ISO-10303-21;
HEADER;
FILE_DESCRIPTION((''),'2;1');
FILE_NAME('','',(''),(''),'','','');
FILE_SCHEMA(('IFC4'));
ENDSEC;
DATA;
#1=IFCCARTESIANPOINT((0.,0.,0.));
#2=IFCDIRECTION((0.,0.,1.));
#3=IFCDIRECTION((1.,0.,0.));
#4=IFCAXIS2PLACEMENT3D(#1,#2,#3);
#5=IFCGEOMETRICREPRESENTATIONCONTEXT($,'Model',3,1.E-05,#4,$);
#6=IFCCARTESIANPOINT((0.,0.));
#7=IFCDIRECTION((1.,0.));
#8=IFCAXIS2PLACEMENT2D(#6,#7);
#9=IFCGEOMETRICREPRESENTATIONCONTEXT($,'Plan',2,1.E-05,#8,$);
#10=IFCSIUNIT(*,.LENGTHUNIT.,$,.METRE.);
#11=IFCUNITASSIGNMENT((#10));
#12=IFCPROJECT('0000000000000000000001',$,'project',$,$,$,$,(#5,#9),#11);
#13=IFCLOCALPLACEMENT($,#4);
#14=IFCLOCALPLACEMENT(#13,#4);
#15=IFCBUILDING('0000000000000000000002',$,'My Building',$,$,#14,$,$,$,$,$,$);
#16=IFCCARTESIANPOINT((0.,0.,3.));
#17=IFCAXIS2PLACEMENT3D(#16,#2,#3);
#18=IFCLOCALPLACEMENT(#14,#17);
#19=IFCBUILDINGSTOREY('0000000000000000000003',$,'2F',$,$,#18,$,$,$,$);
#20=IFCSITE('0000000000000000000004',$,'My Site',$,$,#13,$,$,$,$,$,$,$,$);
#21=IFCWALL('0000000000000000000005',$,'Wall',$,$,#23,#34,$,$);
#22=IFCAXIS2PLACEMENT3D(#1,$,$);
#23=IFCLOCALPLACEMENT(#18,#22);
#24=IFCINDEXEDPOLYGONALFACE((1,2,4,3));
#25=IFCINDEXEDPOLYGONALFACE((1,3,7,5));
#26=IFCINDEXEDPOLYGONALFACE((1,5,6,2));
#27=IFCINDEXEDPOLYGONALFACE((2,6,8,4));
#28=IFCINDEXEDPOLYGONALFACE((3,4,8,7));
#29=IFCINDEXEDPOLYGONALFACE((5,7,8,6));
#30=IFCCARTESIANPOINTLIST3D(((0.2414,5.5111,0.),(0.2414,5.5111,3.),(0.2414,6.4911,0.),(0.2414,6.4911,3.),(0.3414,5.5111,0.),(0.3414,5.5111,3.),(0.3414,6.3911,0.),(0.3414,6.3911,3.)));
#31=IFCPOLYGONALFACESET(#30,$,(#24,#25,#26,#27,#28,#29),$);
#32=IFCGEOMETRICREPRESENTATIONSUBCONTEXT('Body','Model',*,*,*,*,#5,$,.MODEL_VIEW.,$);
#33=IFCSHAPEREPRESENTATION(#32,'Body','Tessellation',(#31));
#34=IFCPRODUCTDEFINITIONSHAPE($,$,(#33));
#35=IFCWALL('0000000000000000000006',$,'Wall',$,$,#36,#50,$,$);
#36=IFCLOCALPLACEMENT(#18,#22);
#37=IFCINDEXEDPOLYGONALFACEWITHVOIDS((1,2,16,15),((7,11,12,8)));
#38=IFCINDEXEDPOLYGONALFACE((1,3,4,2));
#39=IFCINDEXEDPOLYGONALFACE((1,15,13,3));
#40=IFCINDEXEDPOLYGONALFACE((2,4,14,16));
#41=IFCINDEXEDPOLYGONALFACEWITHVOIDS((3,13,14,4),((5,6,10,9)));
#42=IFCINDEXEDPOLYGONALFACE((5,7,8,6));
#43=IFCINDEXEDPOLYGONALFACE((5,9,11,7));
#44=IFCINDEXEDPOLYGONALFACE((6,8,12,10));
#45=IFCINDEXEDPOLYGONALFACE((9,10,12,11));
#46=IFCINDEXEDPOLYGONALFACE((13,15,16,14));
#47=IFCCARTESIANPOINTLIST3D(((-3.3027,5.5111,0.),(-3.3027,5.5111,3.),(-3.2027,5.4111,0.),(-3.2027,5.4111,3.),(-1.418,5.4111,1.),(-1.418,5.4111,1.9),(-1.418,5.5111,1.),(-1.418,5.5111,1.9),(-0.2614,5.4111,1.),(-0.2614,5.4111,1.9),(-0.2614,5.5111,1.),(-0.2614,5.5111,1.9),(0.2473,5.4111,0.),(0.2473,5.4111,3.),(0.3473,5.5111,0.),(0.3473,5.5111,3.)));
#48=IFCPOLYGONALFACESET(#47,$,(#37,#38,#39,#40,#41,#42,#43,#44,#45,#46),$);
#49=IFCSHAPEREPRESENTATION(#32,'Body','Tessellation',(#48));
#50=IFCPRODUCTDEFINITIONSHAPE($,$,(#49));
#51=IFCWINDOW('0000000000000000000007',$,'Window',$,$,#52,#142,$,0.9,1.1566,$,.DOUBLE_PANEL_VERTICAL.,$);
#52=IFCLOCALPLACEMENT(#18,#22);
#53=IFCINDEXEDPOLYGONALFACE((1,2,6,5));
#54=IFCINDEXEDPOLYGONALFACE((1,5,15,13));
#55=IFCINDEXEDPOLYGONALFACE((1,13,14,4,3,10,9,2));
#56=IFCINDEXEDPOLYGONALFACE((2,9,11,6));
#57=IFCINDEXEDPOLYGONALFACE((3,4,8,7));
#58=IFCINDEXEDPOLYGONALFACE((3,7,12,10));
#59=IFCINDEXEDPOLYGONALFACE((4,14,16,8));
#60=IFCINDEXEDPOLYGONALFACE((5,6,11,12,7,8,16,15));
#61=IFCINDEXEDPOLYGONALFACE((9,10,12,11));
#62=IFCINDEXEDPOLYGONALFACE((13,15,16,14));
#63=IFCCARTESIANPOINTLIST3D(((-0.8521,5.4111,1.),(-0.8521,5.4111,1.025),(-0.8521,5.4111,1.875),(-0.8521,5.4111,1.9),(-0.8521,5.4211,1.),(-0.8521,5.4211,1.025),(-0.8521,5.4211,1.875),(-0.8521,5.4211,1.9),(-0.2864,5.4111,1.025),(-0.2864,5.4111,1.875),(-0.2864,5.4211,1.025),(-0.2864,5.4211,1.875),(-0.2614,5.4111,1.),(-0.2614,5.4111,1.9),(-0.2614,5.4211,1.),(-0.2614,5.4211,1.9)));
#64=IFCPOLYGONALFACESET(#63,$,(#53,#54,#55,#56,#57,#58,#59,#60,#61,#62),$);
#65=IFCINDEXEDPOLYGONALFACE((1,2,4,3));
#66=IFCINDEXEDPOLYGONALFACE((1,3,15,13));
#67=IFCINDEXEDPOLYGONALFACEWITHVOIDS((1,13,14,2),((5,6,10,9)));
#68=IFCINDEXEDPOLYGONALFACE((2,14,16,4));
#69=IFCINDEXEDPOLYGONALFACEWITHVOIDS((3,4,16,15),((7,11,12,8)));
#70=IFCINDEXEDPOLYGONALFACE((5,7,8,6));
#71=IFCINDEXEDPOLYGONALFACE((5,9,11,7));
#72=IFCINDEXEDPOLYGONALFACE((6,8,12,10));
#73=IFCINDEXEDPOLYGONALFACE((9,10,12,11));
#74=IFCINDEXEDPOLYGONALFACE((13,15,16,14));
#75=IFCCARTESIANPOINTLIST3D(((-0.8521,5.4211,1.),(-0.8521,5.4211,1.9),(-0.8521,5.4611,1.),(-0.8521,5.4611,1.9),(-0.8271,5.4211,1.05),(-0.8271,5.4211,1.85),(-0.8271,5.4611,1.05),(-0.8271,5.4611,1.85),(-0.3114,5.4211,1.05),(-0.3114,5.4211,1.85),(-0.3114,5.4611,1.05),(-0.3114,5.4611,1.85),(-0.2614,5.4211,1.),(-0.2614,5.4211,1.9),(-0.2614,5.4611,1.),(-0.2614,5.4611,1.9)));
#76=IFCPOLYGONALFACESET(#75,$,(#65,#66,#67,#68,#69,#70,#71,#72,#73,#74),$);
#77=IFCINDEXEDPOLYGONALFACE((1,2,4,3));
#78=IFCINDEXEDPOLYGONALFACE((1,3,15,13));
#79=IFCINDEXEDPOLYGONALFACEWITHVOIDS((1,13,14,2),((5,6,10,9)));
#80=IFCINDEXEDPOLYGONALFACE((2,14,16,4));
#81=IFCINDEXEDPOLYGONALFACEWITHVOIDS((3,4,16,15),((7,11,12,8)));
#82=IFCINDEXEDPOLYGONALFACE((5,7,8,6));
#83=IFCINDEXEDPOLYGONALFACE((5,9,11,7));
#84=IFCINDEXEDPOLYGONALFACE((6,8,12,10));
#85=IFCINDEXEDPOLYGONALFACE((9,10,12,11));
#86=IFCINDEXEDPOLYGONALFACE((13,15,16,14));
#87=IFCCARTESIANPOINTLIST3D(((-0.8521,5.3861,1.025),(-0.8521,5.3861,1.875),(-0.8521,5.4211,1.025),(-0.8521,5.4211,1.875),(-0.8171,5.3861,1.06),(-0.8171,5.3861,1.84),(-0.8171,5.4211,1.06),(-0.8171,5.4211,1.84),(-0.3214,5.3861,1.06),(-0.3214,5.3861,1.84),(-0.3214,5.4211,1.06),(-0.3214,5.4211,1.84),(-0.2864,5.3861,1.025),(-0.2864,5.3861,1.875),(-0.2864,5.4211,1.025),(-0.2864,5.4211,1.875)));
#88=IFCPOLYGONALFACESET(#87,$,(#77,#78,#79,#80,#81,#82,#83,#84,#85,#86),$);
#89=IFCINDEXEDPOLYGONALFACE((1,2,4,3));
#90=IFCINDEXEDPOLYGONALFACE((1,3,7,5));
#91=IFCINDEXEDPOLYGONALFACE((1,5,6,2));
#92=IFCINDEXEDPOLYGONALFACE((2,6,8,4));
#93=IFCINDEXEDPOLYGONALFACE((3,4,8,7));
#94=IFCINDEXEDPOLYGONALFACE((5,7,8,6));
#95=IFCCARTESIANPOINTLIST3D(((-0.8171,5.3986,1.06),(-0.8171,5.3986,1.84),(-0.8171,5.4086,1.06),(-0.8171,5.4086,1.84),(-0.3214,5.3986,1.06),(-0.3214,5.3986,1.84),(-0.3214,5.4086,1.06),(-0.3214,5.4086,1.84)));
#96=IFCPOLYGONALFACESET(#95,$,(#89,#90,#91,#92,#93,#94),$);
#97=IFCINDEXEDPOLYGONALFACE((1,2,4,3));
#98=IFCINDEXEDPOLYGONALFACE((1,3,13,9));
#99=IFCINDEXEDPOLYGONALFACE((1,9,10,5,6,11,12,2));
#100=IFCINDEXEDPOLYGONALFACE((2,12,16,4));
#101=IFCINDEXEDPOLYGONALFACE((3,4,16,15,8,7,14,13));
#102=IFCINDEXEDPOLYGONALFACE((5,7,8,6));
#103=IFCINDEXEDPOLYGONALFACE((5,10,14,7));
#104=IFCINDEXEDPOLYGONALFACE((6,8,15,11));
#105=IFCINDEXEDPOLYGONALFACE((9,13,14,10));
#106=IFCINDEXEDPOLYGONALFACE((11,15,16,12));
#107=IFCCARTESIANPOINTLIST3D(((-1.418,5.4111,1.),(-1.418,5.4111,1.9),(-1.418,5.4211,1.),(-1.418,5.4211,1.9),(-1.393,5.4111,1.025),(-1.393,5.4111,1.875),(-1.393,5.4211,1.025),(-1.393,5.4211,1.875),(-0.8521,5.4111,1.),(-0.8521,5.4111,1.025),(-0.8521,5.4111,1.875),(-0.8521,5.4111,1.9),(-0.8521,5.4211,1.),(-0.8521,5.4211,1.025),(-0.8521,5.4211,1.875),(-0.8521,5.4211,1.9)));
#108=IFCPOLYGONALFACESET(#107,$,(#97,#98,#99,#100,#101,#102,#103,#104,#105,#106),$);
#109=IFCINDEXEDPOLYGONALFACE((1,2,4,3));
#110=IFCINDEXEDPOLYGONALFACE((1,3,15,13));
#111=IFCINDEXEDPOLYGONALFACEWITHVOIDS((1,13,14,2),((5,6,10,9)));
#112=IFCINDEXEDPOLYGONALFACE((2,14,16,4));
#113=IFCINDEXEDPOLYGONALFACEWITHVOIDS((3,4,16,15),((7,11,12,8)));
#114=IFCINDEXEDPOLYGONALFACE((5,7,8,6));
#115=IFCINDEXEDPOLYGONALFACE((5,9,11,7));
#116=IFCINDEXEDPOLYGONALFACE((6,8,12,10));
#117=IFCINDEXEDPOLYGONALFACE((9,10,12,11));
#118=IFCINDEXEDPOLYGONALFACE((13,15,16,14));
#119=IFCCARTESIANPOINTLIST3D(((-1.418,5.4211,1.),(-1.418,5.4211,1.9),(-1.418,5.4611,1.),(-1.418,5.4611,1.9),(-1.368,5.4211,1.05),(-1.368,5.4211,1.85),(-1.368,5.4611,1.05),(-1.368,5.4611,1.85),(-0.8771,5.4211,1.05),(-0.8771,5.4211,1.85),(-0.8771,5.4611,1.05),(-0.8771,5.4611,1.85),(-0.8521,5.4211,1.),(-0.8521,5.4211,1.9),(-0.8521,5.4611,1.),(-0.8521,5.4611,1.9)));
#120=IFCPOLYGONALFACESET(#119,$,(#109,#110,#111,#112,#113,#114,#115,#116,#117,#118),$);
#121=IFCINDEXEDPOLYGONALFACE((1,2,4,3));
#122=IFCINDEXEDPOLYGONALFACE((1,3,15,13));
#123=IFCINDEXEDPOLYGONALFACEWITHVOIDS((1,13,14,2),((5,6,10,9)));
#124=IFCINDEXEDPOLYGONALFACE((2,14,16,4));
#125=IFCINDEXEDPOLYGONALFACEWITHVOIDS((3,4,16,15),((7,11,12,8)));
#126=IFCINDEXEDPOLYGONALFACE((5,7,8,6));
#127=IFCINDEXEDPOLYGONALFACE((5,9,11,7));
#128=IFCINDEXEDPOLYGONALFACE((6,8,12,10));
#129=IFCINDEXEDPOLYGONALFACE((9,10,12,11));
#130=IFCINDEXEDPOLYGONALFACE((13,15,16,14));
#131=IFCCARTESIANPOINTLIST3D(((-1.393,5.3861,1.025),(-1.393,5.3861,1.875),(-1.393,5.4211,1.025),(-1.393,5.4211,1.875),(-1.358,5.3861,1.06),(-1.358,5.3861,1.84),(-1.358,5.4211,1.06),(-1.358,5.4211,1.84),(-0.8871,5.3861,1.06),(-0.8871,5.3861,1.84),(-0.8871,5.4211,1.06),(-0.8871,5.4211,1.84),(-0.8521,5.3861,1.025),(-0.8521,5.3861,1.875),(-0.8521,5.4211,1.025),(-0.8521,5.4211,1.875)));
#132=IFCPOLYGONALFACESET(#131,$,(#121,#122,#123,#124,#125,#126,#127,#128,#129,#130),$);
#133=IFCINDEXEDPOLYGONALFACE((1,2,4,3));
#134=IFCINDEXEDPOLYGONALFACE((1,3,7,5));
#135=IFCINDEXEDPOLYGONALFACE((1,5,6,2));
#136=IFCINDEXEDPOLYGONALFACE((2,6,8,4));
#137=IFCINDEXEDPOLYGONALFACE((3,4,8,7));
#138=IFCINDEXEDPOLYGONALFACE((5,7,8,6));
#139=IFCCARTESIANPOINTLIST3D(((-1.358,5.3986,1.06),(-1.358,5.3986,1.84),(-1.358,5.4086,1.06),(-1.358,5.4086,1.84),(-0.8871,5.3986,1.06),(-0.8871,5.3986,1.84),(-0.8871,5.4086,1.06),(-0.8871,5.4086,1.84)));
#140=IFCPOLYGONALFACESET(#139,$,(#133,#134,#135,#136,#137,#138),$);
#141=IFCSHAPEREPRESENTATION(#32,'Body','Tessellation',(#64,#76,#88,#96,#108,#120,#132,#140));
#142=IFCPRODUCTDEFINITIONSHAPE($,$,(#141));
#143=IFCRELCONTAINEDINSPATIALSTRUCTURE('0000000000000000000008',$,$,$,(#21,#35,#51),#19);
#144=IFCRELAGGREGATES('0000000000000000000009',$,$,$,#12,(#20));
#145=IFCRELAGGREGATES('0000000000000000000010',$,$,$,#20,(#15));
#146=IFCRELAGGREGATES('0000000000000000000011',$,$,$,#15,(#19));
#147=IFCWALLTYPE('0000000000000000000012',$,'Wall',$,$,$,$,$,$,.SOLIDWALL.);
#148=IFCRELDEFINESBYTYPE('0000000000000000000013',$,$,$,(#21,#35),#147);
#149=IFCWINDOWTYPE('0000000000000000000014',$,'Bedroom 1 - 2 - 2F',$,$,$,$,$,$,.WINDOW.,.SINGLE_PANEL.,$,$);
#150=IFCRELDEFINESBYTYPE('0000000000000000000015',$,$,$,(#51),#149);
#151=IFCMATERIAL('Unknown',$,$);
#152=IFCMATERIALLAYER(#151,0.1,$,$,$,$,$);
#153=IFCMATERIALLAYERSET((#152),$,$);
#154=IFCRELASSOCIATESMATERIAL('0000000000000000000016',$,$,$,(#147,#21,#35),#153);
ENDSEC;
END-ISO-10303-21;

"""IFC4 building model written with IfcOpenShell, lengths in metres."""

from ifc_helpers import new_model, entity, si_unit, frame, origin_with_axes, origin_2d_with_axis, place, context, subcontext, project, spatial, line, indexed_curve, outline, extrude, shape, source, transform, mapped, material, layer, layer_set, layer_usage, type_object, type_shapes, element, fill, save


model = new_model("IFC4")

# Units and contexts
model_context = context("Model", 3, precision=1e-05, world=origin_with_axes())
plan_context = context("Plan", 2, precision=1e-05, world=origin_2d_with_axis())
body_context_1 = subcontext(model_context, "Body", "Model", "MODEL_VIEW")
body_context_2 = subcontext(plan_context, "Body", "Plan", "PLAN_VIEW")
ifc_project = project(units=[si_unit("LENGTHUNIT", "METRE")], contexts=[model_context, plan_context])

# Site, building, storey
site_placement = place(None, origin_with_axes())
site = spatial("IfcSite", under=ifc_project, at=site_placement, Name="My Site")
building_placement = place(site_placement, origin_with_axes())
building = spatial("IfcBuilding", under=site, at=building_placement, Name="My Building")
storey_placement = place(building_placement, frame((0.0, 0.0, 3.0), z_axis=(0.0, 0.0, 1.0), x_axis=(1.0, 0.0, 0.0)))
storey = spatial("IfcBuildingStorey", under=building, at=storey_placement, Name="2F")

# Shared definitions
ifc_material = material(Name="Unknown")

# Wall
ifc_layer = layer(ifc_material, 0.1)
ifc_layer_set = layer_set([ifc_layer])
wall_type = type_object("IfcWallType", Name="Wall", PredefinedType="SOLIDWALL", material=ifc_layer_set)
ifc_layer_usage_1 = layer_usage(ifc_layer_set, "AXIS2", "POSITIVE", 0.0)
wall_1_placement = place(storey_placement, frame((0.2414, 6.4911, 0.0), z_axis=(0.0, 0.0, 1.0), x_axis=(0.0, -1.0, 0.0)))
element("IfcWall", 1, at=wall_1_placement, inside=storey, type_object=wall_type, material=ifc_layer_usage_1, Name="Wall", context=body_context_1, shape_type="SweptSolid", body=[
    extrude(outline(indexed_curve([(0.0, 0.0), (0.1, 0.1), (0.98, 0.1), (0.98, 0.0)], segments=[line(1, 2, 3, 4, 1)])), origin_with_axes(), (0.0, 0.0, 1.0), 3.0),
])

# Wall, opening, window
ifc_layer_usage_2 = layer_usage(ifc_layer_set, "AXIS2", "POSITIVE", 0.0)
wall_2_placement = place(storey_placement, frame((0.3473, 5.5111, 0.0), z_axis=(0.0, 0.0, 1.0), x_axis=(-1.0, 0.0, 0.0)))
wall_2 = element("IfcWall", 2, at=wall_2_placement, inside=storey, type_object=wall_type, material=ifc_layer_usage_2, Name="Wall", context=body_context_1, shape_type="SweptSolid", body=[
    extrude(outline(indexed_curve([(0.0, 0.0), (0.1, 0.1), (3.55, 0.1), (3.65, 0.0)], segments=[line(1, 2, 3, 4, 1)])), origin_with_axes(), (0.0, 0.0, 1.0), 3.0),
])
shared_shape_1 = source(origin_with_axes(), body_context_1, "Body", "SweptSolid", [
    extrude(outline(indexed_curve([(0.0, 0.0), (1.1566, 0.0), (1.1566, 0.9), (0.0, 0.9)], segments=[line(1, 2, 3, 4, 1)])), frame((0.0, -0.6, 0.0), z_axis=(0.0, -1.0, 0.0), x_axis=(1.0, 0.0, 0.0)), (0.0, 0.0, -1.0), 1.2),
])
opening_1_placement = place(wall_2_placement, frame((0.6086, 0.0, 1.0), z_axis=(0.0, 0.0, 1.0), x_axis=(1.0, 0.0, 0.0)))
opening_1 = element("IfcOpeningElement", 3, at=opening_1_placement, cuts=wall_2, PredefinedType="OPENING", context=body_context_1, shape_type="MappedRepresentation", body=[
    mapped(shared_shape_1, transform((0.0, 0.0, 0.0), x_axis=(1.0, 0.0, 0.0), y_axis=(0.0, 1.0, 0.0), z_axis=(0.0, 0.0, 1.0), scale=1.0)),
])
window_type_1 = type_object("IfcWindowType", Name="Bedroom 1 - 2 - 2F", PartitioningType="SINGLE_PANEL", PredefinedType="WINDOW")
shared_shape_2 = source(origin_with_axes(), body_context_1, "Body", "SweptSolid", [
    extrude(outline(indexed_curve([(0.5908, 0.0), (0.0, 0.0), (0.0, 0.9), (0.5908, 0.9), (0.5908, 0.875), (0.025, 0.875), (0.025, 0.025), (0.5908, 0.025)], segments=[line(1, 2, 3, 4, 5, 6, 7, 8, 1)])), frame((0.0, 0.09, 0.0), z_axis=(0.0, -1.0, 0.0), x_axis=(1.0, 0.0, 0.0)), (0.0, 0.0, -1.0), 0.01),
    extrude(outline(indexed_curve([(0.0, 0.0), (0.5908, 0.0), (0.5908, 0.9), (0.0, 0.9)], segments=[line(1, 2, 3, 4, 1)]), holes=[indexed_curve([(0.05, 0.05), (0.5658, 0.05), (0.5658, 0.85), (0.05, 0.85)], segments=[line(1, 2, 3, 4, 1)])]), frame((0.0, 0.05, 0.0), z_axis=(0.0, -1.0, 0.0), x_axis=(1.0, 0.0, 0.0)), (0.0, 0.0, -1.0), 0.04),
    extrude(outline(indexed_curve([(0.0, 0.0), (0.5658, 0.0), (0.5658, 0.85), (0.0, 0.85)], segments=[line(1, 2, 3, 4, 1)]), holes=[indexed_curve([(0.035, 0.035), (0.5308, 0.035), (0.5308, 0.815), (0.035, 0.815)], segments=[line(1, 2, 3, 4, 1)])]), frame((0.025, 0.09, 0.025), z_axis=(0.0, -1.0, 0.0), x_axis=(1.0, 0.0, 0.0)), (0.0, 0.0, -1.0), 0.035),
    extrude(outline(indexed_curve([(0.035, 0.035), (0.5308, 0.035), (0.5308, 0.815), (0.035, 0.815)], segments=[line(1, 2, 3, 4, 1)])), frame((0.025, 0.1025, 0.025), z_axis=(0.0, -1.0, 0.0), x_axis=(1.0, 0.0, 0.0)), (0.0, 0.0, -1.0), 0.01),
    extrude(outline(indexed_curve([(0.0, 0.9), (0.5659, 0.9), (0.5659, 0.0), (0.0, 0.0), (0.0, 0.025), (0.5409, 0.025), (0.5409, 0.875), (0.0, 0.875)], segments=[line(1, 2, 3, 4, 5, 6, 7, 8, 1)])), frame((0.5908, 0.09, 0.0), z_axis=(0.0, -1.0, 0.0), x_axis=(1.0, 0.0, 0.0)), (0.0, 0.0, -1.0), 0.01),
    extrude(outline(indexed_curve([(0.0, 0.0), (0.5659, 0.0), (0.5659, 0.9), (0.0, 0.9)], segments=[line(1, 2, 3, 4, 1)]), holes=[indexed_curve([(0.025, 0.05), (0.5159, 0.05), (0.5159, 0.85), (0.025, 0.85)], segments=[line(1, 2, 3, 4, 1)])]), frame((0.5908, 0.05, 0.0), z_axis=(0.0, -1.0, 0.0), x_axis=(1.0, 0.0, 0.0)), (0.0, 0.0, -1.0), 0.04),
    extrude(outline(indexed_curve([(0.0, 0.0), (0.5409, 0.0), (0.5409, 0.85), (0.0, 0.85)], segments=[line(1, 2, 3, 4, 1)]), holes=[indexed_curve([(0.035, 0.035), (0.5059, 0.035), (0.5059, 0.815), (0.035, 0.815)], segments=[line(1, 2, 3, 4, 1)])]), frame((0.5908, 0.09, 0.025), z_axis=(0.0, -1.0, 0.0), x_axis=(1.0, 0.0, 0.0)), (0.0, 0.0, -1.0), 0.035),
    extrude(outline(indexed_curve([(0.035, 0.035), (0.5059, 0.035), (0.5059, 0.815), (0.035, 0.815)], segments=[line(1, 2, 3, 4, 1)])), frame((0.5908, 0.1025, 0.025), z_axis=(0.0, -1.0, 0.0), x_axis=(1.0, 0.0, 0.0)), (0.0, 0.0, -1.0), 0.01),
])
shared_shape_3 = source(origin_with_axes(), body_context_2, "Body", "Curve2D", [
    entity("IfcIndexedPolyCurve", entity("IfcCartesianPointList2D", [[0.05, 0.05], [0.5658, 0.05]])),
    entity("IfcIndexedPolyCurve", entity("IfcCartesianPointList2D", [[0.0, 0.1], [0.025, 0.1], [0.025, 0.09], [0.05, 0.09], [0.05, 0.05], [0.0, 0.05]]), [entity("IfcLineIndex", [1, 2, 3, 4, 5, 6, 1])]),
    entity("IfcIndexedPolyCurve", entity("IfcCartesianPointList2D", [[0.5908, 0.1], [0.5908, 0.1], [0.5908, 0.09], [0.5658, 0.09], [0.5658, 0.05], [0.5908, 0.05]])),
    entity("IfcIndexedPolyCurve", entity("IfcCartesianPointList2D", [[0.025, 0.09], [0.06, 0.09], [0.06, 0.125], [0.025, 0.125]]), [entity("IfcLineIndex", [1, 2, 3, 4, 1])]),
    entity("IfcIndexedPolyCurve", entity("IfcCartesianPointList2D", [[0.5908, 0.09], [0.5558, 0.09], [0.5558, 0.125], [0.5908, 0.125]]), [entity("IfcLineIndex", [1, 2, 3, 4, 1])]),
    entity("IfcIndexedPolyCurve", entity("IfcCartesianPointList2D", [[0.06, 0.09], [0.5558, 0.09]])),
    entity("IfcIndexedPolyCurve", entity("IfcCartesianPointList2D", [[0.06, 0.125], [0.5558, 0.125]])),
    entity("IfcIndexedPolyCurve", entity("IfcCartesianPointList2D", [[0.06, 0.1075], [0.5558, 0.1075]])),
    entity("IfcIndexedPolyCurve", entity("IfcCartesianPointList2D", [[0.6158, 0.05], [1.1066, 0.05]])),
    entity("IfcIndexedPolyCurve", entity("IfcCartesianPointList2D", [[0.5908, 0.1], [0.5908, 0.1], [0.5908, 0.09], [0.6158, 0.09], [0.6158, 0.05], [0.5908, 0.05]])),
    entity("IfcIndexedPolyCurve", entity("IfcCartesianPointList2D", [[1.1566, 0.1], [1.1316, 0.1], [1.1316, 0.09], [1.1066, 0.09], [1.1066, 0.05], [1.1566, 0.05]]), [entity("IfcLineIndex", [1, 2, 3, 4, 5, 6, 1])]),
    entity("IfcIndexedPolyCurve", entity("IfcCartesianPointList2D", [[0.5908, 0.09], [0.6258, 0.09], [0.6258, 0.125], [0.5908, 0.125]]), [entity("IfcLineIndex", [1, 2, 3, 4, 1])]),
    entity("IfcIndexedPolyCurve", entity("IfcCartesianPointList2D", [[1.1316, 0.09], [1.0966, 0.09], [1.0966, 0.125], [1.1316, 0.125]]), [entity("IfcLineIndex", [1, 2, 3, 4, 1])]),
    entity("IfcIndexedPolyCurve", entity("IfcCartesianPointList2D", [[0.6258, 0.09], [1.0966, 0.09]])),
    entity("IfcIndexedPolyCurve", entity("IfcCartesianPointList2D", [[0.6258, 0.125], [1.0966, 0.125]])),
    entity("IfcIndexedPolyCurve", entity("IfcCartesianPointList2D", [[0.6258, 0.1075], [1.0966, 0.1075]])),
])
type_shapes(window_type_1, [shared_shape_2, shared_shape_3])
window_1_placement = place(opening_1_placement, frame((0.0, 0.0, 0.0), z_axis=(0.0, 0.0, 1.0), x_axis=(1.0, 0.0, 0.0)))
window_1 = element("IfcWindow", 4, at=window_1_placement, inside=storey, type_object=window_type_1, Name="Window", OverallHeight=0.9, OverallWidth=1.1566, PartitioningType="DOUBLE_PANEL_VERTICAL", shapes=[
    shape(body_context_1, "Body", "MappedRepresentation", [mapped(shared_shape_2, transform((0.0, 0.0, 0.0), x_axis=(1.0, 0.0, 0.0), y_axis=(0.0, 1.0, 0.0), z_axis=(0.0, 0.0, 1.0), scale=1.0))]),
    shape(body_context_2, "Body", "MappedRepresentation", [mapped(shared_shape_3, transform((0.0, 0.0, 0.0), x_axis=(1.0, 0.0, 0.0), y_axis=(0.0, 1.0, 0.0), z_axis=(0.0, 0.0, 1.0), scale=1.0))]),
])
fill(opening_1, window_1)

save(model, "model.ifc")
